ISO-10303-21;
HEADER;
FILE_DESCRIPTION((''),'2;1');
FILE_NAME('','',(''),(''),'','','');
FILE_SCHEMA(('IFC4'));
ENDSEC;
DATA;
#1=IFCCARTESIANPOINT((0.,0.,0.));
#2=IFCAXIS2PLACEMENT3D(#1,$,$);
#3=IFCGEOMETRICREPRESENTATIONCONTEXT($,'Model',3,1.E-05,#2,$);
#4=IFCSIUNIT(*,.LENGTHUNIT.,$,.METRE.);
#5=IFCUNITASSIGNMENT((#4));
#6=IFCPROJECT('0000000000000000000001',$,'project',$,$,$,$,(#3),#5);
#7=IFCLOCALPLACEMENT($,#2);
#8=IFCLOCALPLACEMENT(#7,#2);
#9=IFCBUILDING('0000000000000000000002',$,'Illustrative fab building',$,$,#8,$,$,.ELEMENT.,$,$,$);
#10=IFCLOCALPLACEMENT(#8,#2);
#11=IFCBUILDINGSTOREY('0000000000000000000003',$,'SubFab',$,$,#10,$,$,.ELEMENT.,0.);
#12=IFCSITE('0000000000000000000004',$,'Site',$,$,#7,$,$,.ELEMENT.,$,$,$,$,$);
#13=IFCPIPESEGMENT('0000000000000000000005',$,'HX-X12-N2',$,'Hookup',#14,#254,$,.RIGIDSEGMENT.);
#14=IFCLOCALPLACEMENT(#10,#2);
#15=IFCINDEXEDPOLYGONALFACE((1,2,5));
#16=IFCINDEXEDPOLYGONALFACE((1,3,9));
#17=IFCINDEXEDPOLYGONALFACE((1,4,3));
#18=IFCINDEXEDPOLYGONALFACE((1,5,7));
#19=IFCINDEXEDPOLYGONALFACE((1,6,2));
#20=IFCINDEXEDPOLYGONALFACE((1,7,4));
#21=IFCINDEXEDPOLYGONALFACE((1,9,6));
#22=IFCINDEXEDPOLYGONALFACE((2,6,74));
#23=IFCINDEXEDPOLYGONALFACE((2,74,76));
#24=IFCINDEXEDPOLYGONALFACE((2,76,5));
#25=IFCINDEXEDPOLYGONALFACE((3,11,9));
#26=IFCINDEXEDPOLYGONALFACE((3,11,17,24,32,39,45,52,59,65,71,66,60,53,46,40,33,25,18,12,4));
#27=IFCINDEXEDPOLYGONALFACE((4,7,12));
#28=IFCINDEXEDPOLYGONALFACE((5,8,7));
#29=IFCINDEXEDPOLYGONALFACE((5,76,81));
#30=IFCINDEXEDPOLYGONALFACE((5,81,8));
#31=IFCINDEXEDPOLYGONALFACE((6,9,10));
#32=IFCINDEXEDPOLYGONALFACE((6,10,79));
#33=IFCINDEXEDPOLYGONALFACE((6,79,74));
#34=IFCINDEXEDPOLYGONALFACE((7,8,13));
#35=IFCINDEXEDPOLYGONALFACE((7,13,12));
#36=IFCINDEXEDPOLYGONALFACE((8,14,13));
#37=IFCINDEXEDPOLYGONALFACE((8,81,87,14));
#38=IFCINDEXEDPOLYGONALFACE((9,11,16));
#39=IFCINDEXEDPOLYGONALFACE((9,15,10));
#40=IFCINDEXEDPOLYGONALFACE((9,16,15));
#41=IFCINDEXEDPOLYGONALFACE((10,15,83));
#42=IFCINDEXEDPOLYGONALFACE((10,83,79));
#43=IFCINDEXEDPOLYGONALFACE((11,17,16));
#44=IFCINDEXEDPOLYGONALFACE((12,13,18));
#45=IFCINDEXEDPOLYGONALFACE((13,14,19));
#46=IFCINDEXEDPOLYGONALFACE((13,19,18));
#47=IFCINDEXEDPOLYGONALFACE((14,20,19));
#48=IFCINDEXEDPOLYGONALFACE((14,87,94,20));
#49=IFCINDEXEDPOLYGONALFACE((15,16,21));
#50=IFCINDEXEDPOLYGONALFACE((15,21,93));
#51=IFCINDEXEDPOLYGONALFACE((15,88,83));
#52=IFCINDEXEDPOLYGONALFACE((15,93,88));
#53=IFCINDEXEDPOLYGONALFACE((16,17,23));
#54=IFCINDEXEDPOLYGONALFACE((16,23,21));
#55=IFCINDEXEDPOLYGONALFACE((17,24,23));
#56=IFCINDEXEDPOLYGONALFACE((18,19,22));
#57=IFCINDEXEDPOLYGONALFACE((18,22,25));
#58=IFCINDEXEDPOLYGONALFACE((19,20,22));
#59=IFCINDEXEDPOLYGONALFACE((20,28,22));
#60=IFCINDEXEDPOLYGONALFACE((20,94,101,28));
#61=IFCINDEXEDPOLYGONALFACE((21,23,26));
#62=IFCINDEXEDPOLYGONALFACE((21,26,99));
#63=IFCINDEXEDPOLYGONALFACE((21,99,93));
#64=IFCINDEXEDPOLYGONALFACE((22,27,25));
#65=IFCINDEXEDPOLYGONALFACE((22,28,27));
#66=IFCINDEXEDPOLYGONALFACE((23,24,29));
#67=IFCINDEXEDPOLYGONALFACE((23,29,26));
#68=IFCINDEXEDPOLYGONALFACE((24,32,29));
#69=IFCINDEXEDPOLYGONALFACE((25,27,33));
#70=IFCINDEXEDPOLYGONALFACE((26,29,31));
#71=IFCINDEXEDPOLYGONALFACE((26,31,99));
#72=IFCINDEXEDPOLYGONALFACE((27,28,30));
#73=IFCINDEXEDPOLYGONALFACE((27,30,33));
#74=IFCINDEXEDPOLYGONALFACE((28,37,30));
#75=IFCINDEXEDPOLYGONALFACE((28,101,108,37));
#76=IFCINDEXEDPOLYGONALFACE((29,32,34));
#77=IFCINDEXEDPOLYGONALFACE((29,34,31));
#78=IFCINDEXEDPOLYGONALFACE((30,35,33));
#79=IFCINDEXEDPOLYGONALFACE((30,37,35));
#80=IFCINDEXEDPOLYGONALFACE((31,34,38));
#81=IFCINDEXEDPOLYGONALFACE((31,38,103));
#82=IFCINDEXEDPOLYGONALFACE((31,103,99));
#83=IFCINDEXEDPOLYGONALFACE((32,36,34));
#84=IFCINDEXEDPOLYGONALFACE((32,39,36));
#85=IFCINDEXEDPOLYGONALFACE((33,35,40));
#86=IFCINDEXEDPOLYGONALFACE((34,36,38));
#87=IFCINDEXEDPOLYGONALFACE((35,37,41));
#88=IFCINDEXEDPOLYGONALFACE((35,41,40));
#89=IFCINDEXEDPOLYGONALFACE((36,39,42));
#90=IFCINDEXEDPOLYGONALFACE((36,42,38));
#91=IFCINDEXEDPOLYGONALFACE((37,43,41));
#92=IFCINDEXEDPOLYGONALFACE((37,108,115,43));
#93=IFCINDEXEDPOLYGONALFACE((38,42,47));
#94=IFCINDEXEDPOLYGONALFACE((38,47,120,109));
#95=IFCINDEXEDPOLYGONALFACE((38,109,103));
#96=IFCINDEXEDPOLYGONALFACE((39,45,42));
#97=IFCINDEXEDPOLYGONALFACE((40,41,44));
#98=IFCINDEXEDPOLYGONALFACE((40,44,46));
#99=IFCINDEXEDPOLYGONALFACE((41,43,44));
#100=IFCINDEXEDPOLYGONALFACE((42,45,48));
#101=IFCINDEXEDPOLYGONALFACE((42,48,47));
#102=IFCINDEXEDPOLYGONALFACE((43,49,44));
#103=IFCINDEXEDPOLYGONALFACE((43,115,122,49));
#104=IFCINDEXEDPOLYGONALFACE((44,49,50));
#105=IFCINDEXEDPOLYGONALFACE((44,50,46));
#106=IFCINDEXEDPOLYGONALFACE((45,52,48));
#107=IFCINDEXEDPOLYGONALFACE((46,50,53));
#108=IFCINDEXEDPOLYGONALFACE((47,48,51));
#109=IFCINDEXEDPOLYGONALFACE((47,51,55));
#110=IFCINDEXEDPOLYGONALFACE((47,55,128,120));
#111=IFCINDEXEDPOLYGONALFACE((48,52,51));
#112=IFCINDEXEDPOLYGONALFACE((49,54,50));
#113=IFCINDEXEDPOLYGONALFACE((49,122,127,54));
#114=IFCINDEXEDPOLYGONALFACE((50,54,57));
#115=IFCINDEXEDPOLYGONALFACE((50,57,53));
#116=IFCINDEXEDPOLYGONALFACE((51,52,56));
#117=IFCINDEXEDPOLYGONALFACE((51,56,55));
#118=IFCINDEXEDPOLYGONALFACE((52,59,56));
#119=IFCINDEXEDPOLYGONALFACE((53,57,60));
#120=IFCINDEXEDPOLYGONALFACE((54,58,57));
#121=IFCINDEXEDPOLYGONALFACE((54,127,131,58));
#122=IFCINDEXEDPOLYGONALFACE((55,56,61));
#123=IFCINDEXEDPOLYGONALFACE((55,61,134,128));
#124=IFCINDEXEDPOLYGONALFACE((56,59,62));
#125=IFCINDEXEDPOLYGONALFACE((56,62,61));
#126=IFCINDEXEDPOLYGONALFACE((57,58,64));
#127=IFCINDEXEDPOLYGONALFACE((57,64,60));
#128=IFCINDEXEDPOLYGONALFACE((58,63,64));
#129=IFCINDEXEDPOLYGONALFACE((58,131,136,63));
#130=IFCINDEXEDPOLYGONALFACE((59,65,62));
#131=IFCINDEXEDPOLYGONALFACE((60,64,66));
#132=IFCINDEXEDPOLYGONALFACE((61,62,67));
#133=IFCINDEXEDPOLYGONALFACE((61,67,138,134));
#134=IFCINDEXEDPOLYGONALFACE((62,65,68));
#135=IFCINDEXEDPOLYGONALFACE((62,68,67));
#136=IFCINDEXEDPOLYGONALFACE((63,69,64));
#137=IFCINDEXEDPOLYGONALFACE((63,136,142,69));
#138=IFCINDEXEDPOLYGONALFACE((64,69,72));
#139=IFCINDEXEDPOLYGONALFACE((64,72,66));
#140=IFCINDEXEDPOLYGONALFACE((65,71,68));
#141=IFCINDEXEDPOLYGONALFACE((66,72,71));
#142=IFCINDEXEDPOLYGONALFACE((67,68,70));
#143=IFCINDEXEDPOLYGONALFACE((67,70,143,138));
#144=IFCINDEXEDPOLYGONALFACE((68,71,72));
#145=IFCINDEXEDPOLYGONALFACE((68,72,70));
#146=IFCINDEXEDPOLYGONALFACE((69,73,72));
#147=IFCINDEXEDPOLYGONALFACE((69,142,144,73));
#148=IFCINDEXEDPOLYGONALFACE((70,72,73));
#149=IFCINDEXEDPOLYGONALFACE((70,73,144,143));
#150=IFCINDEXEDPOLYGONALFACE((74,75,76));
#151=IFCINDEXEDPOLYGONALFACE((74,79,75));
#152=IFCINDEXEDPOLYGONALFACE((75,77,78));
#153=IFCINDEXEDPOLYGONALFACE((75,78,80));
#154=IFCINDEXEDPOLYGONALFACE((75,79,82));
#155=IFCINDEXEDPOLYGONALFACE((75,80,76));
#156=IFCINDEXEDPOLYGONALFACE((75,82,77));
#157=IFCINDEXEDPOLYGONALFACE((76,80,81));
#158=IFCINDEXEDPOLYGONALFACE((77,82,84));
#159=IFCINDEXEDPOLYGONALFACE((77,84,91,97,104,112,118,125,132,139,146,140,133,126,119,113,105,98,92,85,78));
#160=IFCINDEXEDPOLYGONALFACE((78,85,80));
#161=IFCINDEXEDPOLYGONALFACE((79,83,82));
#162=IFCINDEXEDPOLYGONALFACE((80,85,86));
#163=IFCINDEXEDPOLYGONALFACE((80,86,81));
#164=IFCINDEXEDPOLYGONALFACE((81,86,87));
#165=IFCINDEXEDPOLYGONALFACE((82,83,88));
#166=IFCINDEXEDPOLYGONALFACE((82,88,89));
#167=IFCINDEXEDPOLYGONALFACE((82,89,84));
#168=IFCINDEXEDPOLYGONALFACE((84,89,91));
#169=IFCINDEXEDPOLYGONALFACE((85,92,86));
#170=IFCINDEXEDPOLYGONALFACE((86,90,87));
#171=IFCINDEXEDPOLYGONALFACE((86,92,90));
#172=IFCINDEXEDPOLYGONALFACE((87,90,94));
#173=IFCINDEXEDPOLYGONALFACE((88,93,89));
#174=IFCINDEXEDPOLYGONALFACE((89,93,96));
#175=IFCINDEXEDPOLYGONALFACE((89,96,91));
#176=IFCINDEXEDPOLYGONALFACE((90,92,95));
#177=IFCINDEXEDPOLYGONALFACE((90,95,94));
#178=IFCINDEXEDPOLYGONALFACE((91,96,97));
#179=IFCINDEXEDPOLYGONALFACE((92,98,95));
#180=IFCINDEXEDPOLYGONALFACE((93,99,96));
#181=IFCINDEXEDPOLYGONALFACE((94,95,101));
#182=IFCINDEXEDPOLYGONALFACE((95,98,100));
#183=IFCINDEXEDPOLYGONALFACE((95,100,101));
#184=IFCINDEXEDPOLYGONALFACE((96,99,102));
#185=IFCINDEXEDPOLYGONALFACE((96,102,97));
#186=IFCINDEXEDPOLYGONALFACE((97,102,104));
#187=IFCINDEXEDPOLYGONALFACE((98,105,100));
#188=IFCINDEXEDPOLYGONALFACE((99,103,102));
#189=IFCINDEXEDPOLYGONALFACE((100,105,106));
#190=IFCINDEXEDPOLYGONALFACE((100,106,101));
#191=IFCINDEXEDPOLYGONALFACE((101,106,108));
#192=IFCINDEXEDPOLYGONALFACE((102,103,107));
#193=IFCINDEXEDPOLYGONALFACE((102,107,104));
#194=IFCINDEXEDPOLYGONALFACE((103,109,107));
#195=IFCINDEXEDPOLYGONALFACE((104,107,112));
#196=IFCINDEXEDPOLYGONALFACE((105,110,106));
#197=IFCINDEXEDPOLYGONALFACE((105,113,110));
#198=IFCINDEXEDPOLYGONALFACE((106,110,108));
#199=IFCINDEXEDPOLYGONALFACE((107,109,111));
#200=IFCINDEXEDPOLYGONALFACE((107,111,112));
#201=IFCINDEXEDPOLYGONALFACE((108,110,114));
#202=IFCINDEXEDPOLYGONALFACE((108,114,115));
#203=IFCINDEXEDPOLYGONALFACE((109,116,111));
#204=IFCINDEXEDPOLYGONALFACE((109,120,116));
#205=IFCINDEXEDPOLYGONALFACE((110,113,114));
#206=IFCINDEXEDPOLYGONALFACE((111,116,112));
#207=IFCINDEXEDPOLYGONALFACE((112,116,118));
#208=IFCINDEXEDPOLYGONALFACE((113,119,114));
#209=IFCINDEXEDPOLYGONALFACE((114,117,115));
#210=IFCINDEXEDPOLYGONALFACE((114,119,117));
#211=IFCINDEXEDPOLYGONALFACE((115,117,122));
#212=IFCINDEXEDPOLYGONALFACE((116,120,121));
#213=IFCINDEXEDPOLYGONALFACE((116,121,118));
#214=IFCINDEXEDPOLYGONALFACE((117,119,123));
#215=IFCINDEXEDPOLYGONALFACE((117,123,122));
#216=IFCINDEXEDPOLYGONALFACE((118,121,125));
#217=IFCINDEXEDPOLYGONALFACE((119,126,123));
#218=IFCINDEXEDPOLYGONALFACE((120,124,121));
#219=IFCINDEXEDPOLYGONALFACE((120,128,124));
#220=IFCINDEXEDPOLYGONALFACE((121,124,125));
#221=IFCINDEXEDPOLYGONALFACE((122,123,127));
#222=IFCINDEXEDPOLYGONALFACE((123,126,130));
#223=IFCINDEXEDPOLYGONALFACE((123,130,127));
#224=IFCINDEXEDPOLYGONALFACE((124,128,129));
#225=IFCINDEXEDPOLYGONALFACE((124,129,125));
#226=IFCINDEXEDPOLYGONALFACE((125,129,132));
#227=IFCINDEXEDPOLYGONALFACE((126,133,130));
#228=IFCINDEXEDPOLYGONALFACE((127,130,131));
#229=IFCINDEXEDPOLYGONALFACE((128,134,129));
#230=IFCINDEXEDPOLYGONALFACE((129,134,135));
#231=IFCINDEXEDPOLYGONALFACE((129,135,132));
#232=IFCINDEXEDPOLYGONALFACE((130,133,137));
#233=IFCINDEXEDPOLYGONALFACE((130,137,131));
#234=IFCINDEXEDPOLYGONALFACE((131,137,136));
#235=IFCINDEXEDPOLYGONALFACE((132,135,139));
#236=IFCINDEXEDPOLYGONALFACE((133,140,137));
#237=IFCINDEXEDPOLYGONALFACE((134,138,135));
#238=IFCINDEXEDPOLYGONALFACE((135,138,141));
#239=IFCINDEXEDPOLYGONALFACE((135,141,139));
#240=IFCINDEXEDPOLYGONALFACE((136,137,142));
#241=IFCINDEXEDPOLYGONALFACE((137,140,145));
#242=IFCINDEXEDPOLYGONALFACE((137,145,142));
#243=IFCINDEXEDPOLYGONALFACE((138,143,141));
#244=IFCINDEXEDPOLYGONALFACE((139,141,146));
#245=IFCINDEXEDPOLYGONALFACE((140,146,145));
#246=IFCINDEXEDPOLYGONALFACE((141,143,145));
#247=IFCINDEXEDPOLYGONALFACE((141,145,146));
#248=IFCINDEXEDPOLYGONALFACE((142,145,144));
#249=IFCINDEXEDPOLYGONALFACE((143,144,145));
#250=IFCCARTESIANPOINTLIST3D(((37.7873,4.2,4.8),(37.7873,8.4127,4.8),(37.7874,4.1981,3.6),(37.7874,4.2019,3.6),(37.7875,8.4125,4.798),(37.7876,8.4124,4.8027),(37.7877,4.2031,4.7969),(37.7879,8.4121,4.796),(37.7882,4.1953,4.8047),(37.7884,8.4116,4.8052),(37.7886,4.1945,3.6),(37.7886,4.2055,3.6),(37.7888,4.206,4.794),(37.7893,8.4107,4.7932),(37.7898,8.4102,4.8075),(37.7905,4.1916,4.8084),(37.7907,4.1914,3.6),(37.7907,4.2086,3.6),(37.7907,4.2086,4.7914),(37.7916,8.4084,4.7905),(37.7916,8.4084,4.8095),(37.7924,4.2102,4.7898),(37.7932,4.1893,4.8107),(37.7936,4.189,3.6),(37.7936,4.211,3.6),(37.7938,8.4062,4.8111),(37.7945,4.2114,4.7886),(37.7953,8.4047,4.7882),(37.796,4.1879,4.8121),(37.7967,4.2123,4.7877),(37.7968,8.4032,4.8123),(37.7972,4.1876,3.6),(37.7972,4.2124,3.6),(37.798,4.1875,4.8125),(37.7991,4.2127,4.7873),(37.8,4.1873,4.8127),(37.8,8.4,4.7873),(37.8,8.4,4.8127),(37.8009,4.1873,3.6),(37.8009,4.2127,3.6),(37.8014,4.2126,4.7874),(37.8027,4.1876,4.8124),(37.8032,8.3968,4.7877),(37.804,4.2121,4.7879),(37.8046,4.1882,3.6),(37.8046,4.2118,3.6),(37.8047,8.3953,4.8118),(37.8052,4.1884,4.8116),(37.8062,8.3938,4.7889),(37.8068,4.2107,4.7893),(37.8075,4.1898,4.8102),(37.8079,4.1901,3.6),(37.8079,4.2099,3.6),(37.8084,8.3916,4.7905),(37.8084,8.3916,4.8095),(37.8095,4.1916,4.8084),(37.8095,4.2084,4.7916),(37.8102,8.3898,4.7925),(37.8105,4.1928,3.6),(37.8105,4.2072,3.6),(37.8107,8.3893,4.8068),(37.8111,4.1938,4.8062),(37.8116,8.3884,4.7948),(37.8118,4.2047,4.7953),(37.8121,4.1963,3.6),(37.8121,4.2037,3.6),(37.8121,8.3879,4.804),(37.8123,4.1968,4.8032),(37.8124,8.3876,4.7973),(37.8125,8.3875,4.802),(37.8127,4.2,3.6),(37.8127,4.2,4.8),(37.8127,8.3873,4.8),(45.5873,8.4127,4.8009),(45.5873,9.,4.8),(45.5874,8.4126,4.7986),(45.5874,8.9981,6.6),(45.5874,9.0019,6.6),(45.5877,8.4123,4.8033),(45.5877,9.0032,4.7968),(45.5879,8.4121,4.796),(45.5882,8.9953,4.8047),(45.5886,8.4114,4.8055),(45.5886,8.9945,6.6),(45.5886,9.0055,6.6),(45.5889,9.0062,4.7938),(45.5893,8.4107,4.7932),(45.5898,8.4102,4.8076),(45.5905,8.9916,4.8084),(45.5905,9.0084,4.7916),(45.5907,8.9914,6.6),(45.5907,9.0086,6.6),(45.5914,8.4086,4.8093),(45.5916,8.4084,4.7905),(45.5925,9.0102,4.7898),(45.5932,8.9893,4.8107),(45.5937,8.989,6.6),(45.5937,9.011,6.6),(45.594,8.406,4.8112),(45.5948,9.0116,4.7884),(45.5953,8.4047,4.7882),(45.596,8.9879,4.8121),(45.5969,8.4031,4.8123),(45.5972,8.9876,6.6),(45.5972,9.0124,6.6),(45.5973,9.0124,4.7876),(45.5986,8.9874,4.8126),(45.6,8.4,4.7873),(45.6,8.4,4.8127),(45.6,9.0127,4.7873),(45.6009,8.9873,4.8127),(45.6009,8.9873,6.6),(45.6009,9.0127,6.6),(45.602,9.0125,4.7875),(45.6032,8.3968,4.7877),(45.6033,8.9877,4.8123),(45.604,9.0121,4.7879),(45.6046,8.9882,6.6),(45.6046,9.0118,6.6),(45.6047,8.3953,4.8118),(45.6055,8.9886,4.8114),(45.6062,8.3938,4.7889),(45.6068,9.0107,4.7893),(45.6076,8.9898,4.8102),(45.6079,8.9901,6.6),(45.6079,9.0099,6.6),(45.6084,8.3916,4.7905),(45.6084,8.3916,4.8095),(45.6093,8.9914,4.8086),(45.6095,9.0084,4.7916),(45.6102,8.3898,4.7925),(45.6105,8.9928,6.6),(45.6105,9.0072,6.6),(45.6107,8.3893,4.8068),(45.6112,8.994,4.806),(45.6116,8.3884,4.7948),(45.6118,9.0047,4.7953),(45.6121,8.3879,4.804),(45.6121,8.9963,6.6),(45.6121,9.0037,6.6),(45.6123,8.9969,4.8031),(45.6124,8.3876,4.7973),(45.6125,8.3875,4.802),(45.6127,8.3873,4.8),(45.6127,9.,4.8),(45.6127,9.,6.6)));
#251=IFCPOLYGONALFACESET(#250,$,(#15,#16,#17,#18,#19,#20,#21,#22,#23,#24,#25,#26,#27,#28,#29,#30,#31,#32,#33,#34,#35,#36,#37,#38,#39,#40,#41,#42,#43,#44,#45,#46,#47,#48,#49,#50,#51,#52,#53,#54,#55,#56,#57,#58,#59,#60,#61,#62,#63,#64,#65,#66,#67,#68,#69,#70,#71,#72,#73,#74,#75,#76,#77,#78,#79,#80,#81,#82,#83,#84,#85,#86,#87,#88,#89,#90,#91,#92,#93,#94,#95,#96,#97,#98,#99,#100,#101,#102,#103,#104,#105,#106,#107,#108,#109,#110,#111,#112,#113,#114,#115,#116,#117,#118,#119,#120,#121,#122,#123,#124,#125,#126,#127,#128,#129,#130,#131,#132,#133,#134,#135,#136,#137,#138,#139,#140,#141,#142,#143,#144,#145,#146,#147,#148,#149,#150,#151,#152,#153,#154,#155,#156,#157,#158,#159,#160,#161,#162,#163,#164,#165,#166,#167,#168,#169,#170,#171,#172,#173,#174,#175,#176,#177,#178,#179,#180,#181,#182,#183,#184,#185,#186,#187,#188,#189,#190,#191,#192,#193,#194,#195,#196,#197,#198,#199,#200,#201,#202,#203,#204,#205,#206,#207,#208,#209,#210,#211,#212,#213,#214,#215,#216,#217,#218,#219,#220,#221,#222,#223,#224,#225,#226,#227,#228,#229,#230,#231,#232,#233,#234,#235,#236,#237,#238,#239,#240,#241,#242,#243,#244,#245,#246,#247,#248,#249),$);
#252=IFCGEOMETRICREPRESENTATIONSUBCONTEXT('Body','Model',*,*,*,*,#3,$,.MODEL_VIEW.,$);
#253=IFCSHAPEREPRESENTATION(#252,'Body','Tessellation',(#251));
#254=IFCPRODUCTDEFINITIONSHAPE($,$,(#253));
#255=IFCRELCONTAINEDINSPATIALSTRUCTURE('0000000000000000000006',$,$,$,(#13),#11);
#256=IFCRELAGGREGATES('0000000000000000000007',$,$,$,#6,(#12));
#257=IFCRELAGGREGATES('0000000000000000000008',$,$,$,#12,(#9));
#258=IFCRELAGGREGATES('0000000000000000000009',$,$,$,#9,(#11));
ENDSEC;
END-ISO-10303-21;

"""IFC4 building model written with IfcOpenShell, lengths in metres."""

from ifc_helpers import new_model, entity, si_unit, origin, place, context, subcontext, project, spatial, element, save


model = new_model("IFC4")

# Units and contexts
model_context = context("Model", 3, precision=1e-05, world=origin())
body_context = subcontext(model_context, "Body", "Model", "MODEL_VIEW")
ifc_project = project(units=[si_unit("LENGTHUNIT", "METRE")], contexts=[model_context])

# Site, building, storey
site_placement = place(None, origin())
site = spatial("IfcSite", under=ifc_project, at=site_placement, Name="Site", CompositionType="ELEMENT")
building_placement = place(site_placement, origin())
building = spatial("IfcBuilding", under=site, at=building_placement, Name="Illustrative fab building", CompositionType="ELEMENT")
storey_placement = place(building_placement, origin())
storey = spatial("IfcBuildingStorey", under=building, at=storey_placement, Name="SubFab", CompositionType="ELEMENT", Elevation=0.0)

# Pipe segment
pipe_segment_1_placement = place(storey_placement, origin())
element("IfcPipeSegment", 1, at=pipe_segment_1_placement, inside=storey, Name="HX-X12-N2", ObjectType="Hookup", PredefinedType="RIGIDSEGMENT", context=body_context, shape_type="AdvancedSweptSolid", body=[
    entity("IfcSweptDiskSolid", entity("IfcPolyline", [entity("IfcCartesianPoint", [37.8, 4.2, 3.6]), entity("IfcCartesianPoint", [37.8, 4.2, 4.8]), entity("IfcCartesianPoint", [37.8, 8.4, 4.8]), entity("IfcCartesianPoint", [45.6, 8.4, 4.8]), entity("IfcCartesianPoint", [45.6, 9.0, 4.8]), entity("IfcCartesianPoint", [45.6, 9.0, 6.6])]), 0.0127),
])

save(model, "model.ifc")
